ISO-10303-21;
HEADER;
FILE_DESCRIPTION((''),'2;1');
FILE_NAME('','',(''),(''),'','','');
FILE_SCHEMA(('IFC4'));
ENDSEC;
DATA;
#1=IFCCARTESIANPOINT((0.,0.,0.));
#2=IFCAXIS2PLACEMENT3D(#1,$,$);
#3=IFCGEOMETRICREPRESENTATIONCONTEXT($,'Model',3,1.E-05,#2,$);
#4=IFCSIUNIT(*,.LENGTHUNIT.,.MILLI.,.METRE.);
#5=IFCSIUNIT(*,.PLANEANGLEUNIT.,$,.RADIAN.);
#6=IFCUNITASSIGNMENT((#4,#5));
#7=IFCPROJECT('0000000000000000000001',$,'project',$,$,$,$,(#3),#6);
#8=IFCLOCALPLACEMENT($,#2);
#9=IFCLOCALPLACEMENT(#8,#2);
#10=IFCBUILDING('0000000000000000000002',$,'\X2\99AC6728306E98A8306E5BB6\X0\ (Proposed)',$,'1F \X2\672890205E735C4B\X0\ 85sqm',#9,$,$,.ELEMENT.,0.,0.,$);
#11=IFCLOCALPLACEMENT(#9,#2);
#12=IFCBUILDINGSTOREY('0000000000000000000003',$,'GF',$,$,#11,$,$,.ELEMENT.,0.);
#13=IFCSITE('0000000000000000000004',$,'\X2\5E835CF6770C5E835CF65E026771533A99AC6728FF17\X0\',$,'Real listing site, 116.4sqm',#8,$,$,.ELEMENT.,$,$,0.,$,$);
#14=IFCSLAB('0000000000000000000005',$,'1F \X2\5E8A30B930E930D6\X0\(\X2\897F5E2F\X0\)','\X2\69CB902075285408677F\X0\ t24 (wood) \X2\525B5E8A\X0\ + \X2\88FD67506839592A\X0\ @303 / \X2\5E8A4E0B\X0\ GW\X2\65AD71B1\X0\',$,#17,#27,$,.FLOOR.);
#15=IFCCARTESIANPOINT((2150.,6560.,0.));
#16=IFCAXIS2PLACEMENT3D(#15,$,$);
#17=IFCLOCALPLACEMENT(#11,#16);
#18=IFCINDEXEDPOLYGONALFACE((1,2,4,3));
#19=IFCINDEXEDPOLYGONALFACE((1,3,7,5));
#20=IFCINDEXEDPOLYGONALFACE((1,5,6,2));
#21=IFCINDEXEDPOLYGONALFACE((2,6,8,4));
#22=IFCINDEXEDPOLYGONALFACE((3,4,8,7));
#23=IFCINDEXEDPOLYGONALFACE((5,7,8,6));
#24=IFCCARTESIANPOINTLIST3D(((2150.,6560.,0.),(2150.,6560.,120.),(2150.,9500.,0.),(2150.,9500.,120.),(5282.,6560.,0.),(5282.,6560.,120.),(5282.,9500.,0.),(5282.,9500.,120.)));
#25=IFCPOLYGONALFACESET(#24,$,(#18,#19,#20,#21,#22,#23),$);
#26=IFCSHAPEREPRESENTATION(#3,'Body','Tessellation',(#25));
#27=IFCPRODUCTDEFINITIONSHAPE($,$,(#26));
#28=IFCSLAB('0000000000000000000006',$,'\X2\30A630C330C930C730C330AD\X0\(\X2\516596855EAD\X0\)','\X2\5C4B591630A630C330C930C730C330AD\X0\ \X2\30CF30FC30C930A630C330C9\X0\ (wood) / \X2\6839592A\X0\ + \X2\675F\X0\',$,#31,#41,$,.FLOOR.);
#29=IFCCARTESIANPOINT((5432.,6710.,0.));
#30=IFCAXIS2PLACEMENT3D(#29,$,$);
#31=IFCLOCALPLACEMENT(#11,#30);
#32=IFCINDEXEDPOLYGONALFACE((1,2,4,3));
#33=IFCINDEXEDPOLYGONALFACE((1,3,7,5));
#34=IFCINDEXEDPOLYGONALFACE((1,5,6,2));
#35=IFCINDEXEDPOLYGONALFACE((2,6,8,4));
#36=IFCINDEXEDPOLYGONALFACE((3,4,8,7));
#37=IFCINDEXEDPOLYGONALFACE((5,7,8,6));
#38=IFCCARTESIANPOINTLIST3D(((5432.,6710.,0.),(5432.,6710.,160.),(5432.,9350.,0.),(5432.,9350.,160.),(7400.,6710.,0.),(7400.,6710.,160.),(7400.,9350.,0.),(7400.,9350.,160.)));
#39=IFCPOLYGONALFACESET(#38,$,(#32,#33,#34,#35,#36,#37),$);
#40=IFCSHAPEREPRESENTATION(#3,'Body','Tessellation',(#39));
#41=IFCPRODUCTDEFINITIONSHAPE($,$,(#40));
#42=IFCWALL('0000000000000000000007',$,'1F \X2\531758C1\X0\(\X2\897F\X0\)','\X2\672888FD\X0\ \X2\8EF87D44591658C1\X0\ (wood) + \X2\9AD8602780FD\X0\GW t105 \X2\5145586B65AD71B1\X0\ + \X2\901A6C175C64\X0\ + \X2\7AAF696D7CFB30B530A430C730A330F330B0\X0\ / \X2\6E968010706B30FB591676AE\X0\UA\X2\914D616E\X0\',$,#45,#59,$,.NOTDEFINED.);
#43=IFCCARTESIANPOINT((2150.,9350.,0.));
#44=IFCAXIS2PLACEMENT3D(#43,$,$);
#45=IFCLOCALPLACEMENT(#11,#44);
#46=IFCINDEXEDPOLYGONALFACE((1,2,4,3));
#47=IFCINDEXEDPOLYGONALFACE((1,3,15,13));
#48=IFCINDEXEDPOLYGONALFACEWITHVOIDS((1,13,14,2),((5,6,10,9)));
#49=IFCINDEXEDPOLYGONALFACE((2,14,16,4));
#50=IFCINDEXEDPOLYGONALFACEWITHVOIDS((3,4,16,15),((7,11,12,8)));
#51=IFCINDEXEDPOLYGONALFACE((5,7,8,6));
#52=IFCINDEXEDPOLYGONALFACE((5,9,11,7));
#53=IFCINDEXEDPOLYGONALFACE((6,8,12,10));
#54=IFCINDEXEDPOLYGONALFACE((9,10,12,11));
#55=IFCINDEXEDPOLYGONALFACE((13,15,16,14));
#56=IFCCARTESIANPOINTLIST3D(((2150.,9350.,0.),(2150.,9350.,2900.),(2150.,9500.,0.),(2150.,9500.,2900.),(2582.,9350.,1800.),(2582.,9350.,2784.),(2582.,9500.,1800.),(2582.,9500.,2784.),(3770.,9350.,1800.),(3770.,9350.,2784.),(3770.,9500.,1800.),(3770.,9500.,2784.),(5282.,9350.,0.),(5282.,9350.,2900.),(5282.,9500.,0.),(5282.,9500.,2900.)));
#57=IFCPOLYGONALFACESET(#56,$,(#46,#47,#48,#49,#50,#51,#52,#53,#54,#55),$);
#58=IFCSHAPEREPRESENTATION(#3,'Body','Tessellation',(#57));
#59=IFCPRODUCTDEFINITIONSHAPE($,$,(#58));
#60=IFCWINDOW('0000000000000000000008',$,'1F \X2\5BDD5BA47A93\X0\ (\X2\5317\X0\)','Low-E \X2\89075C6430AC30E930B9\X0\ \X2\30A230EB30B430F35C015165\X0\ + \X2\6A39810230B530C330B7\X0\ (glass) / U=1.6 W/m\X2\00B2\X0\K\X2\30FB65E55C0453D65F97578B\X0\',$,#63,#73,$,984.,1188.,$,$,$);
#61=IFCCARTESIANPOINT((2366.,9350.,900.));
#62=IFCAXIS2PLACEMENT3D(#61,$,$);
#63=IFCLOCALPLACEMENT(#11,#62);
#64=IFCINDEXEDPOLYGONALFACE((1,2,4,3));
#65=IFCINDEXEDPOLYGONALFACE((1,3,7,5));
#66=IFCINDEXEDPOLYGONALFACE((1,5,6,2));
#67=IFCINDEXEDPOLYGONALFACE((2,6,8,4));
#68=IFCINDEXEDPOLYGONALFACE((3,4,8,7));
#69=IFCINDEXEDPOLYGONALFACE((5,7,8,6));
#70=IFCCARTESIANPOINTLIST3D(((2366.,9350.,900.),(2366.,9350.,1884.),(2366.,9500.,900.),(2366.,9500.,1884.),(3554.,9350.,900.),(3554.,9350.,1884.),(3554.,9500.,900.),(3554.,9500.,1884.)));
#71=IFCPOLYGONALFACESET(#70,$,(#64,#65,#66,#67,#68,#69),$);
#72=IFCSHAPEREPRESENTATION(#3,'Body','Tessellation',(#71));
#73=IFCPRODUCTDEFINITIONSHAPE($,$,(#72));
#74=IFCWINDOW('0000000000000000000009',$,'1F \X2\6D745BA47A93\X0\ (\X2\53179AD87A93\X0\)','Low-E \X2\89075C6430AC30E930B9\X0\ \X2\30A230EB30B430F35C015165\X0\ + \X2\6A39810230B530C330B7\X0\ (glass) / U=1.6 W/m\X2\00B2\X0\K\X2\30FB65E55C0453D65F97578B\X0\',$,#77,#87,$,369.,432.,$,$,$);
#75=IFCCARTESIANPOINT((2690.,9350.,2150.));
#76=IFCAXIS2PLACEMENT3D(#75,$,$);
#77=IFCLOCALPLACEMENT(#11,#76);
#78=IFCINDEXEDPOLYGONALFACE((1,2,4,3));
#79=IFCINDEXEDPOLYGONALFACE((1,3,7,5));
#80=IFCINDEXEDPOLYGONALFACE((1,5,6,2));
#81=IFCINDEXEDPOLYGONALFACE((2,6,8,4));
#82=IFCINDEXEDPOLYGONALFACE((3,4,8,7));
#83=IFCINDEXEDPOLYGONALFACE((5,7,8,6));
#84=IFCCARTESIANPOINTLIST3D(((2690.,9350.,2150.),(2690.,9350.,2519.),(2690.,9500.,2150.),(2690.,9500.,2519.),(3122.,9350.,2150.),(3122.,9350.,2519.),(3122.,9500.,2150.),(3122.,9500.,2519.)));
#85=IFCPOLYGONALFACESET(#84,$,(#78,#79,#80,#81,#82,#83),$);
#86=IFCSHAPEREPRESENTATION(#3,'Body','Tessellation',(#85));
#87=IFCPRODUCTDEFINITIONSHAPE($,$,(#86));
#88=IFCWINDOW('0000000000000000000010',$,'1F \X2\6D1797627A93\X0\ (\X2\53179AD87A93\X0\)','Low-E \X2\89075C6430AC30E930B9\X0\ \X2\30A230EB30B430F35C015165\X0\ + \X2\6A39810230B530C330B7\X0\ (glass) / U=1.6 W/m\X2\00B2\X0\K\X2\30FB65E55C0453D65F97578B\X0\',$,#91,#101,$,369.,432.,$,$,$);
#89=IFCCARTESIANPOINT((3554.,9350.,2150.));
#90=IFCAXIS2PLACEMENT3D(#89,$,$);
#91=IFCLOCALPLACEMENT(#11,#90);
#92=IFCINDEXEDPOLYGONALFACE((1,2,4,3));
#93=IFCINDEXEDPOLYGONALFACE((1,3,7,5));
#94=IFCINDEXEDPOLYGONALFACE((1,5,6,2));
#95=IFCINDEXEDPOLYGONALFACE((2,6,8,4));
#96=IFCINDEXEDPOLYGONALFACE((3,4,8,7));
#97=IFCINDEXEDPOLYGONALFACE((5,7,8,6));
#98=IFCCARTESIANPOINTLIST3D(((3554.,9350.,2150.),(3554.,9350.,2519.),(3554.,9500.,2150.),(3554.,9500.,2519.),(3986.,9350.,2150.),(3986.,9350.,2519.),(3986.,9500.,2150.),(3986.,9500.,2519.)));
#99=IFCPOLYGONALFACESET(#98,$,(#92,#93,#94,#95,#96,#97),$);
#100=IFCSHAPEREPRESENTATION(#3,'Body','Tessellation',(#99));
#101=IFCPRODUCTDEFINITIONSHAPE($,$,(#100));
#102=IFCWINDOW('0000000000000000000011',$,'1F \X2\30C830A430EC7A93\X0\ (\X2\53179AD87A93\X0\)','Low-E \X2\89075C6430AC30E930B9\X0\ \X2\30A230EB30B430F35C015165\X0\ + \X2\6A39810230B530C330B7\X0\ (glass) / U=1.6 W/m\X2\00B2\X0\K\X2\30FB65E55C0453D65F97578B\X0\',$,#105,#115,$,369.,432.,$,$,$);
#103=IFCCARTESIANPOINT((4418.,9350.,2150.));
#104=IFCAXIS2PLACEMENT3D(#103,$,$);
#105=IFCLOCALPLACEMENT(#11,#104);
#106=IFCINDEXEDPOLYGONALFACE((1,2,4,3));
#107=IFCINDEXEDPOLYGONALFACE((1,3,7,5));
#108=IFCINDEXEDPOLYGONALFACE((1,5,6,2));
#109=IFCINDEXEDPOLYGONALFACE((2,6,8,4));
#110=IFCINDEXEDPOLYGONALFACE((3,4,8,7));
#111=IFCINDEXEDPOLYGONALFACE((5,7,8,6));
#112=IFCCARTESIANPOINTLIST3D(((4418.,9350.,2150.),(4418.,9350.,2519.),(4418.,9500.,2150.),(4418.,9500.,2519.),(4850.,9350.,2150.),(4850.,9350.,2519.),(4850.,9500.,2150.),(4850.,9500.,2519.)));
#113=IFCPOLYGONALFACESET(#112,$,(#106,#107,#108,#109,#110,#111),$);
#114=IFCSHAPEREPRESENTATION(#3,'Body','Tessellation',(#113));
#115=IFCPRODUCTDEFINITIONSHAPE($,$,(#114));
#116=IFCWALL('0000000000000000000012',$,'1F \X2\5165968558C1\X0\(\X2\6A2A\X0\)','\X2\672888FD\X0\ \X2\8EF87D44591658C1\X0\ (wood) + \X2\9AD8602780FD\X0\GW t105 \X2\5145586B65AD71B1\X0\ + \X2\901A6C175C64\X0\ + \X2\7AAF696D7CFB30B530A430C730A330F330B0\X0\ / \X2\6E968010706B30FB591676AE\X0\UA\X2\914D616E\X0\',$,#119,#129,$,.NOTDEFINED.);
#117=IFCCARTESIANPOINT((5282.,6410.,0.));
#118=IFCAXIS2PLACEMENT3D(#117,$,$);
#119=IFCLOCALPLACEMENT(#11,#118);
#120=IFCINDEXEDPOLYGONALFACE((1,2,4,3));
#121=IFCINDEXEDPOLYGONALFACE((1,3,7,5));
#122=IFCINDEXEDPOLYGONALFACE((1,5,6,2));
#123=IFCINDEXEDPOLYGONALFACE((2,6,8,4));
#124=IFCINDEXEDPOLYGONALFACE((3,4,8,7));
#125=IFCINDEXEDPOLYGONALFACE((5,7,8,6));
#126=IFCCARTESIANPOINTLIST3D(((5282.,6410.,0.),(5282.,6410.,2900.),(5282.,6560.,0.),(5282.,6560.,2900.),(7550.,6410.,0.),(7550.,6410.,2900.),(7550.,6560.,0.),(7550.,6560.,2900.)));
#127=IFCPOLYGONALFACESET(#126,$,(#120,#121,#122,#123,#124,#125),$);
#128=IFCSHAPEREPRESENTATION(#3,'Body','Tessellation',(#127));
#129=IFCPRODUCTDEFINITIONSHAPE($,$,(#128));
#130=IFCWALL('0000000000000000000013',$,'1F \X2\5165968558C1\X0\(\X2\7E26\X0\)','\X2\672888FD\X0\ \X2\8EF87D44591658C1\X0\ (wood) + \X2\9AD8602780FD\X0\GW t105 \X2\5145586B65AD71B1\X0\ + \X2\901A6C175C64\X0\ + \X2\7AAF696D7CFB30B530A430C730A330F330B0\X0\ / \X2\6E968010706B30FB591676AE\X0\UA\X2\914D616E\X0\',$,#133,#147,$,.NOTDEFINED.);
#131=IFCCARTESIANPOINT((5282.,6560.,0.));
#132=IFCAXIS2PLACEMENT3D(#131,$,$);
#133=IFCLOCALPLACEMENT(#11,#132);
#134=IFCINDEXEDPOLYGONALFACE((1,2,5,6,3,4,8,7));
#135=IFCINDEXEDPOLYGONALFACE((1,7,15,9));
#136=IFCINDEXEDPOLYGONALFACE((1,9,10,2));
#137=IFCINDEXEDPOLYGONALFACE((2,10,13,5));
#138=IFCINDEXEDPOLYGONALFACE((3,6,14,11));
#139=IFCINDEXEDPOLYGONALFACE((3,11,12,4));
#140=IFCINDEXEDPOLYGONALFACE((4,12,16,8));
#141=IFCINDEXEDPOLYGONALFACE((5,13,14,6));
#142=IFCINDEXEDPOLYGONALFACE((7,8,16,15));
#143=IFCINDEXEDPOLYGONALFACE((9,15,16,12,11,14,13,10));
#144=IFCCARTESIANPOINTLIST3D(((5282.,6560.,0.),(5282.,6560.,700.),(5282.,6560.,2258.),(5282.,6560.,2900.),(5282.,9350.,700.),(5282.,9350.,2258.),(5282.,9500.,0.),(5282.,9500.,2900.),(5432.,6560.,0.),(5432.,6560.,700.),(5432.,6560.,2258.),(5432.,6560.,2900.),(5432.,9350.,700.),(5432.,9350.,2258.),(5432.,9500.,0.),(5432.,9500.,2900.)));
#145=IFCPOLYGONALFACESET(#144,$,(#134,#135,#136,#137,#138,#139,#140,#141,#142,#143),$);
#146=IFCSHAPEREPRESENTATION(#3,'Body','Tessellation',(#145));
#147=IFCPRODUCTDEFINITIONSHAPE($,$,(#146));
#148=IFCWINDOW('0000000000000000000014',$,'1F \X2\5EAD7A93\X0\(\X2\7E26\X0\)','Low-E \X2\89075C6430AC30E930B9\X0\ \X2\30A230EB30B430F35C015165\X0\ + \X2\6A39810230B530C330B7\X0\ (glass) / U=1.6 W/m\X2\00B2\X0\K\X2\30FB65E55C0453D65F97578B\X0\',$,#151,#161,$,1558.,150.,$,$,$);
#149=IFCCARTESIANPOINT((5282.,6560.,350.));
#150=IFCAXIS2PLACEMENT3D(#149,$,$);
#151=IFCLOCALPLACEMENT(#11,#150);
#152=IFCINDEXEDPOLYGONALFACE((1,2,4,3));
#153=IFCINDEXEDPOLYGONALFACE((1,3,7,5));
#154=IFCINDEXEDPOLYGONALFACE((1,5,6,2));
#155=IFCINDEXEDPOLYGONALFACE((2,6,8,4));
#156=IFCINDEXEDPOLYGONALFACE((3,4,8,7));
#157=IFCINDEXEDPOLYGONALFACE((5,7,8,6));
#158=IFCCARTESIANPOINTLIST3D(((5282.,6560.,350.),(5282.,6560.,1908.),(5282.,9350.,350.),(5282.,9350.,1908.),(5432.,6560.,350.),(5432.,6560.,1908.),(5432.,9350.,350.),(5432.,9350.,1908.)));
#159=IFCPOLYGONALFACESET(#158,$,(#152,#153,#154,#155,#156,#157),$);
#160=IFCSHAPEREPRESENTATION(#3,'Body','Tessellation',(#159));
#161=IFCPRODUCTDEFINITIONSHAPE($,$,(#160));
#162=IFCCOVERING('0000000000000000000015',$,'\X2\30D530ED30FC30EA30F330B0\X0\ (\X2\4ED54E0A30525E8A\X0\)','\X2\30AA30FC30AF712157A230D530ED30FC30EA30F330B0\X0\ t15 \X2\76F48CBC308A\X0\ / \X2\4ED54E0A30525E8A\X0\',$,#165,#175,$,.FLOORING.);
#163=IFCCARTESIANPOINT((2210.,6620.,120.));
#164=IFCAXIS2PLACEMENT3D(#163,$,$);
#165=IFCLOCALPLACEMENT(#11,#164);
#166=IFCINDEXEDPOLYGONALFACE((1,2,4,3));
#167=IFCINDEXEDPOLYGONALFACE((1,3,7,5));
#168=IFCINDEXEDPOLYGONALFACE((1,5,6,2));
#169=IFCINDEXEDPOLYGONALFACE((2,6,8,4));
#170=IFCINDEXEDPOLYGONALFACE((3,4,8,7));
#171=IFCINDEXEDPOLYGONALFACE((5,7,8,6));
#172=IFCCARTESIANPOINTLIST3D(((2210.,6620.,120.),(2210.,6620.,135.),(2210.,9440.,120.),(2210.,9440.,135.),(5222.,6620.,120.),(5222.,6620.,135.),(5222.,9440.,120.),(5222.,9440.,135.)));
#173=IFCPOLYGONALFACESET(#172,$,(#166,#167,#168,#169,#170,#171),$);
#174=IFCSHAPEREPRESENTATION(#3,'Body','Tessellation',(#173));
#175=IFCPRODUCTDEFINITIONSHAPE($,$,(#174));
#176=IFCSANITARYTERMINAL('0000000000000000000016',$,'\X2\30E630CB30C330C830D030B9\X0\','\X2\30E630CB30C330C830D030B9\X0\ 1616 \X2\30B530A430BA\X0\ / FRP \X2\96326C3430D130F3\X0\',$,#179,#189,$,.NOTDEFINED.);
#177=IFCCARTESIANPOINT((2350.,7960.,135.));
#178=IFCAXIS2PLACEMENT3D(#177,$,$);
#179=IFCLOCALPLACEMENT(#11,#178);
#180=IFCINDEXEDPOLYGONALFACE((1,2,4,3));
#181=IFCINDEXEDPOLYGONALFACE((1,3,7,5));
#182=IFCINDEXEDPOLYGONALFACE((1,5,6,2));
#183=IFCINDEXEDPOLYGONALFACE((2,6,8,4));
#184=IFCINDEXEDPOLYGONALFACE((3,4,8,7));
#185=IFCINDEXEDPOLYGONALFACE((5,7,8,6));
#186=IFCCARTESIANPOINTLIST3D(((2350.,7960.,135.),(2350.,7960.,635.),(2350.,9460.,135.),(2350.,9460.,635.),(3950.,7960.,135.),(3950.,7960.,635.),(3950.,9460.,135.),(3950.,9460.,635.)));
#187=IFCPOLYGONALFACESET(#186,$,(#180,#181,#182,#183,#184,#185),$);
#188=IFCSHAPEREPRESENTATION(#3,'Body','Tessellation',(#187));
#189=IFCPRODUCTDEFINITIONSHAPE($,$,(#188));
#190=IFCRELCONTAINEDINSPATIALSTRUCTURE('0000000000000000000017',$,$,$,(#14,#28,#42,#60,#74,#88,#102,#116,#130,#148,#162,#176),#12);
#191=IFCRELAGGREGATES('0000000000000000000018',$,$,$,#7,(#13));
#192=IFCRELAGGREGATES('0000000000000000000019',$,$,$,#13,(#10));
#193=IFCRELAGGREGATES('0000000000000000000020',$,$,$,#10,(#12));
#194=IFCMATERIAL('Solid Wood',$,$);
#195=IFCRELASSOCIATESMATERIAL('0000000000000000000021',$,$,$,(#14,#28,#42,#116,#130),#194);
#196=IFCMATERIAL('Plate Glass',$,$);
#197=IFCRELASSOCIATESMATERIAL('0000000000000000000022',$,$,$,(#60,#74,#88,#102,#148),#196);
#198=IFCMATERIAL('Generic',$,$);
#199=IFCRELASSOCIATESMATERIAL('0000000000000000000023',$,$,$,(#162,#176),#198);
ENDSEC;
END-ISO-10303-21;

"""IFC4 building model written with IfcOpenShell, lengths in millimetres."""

from ifc_helpers import new_model, si_unit, frame, frame_2d, origin, place, context, project, spatial, rectangle, extrude, material, element, fill, save


model = new_model("IFC4")

# Units and contexts
model_context = context("Model", 3, precision=1e-05, world=origin())
ifc_project = project(units=[si_unit("LENGTHUNIT", "METRE", prefix="MILLI"), si_unit("PLANEANGLEUNIT", "RADIAN")], contexts=[model_context])

# Site, building, storey
site_placement = place(None, origin())
site = spatial("IfcSite", under=ifc_project, at=site_placement, Name="広島県広島市東区馬木７", ObjectType="Real listing site, 116.4sqm", CompositionType="ELEMENT", RefElevation=0.0)
building_placement = place(site_placement, origin())
building = spatial("IfcBuilding", under=site, at=building_placement, Name="馬木の風の家 (Proposed)", ObjectType="1F 木造平屋 85sqm", CompositionType="ELEMENT", ElevationOfRefHeight=0.0, ElevationOfTerrain=0.0)
storey_placement = place(building_placement, origin())
storey = spatial("IfcBuildingStorey", under=building, at=storey_placement, Name="GF", CompositionType="ELEMENT", Elevation=0.0)

# Slabs
ifc_material_1 = material(Name="Solid Wood")
slab_1_placement = place(storey_placement, frame((2150.0, 6560.0, 0.0)))
element("IfcSlab", 1, at=slab_1_placement, inside=storey, material=ifc_material_1, Name="1F 床スラブ(西帯)", Description="構造用合板 t24 (wood) 剛床 + 製材根太 @303 / 床下 GW断熱", PredefinedType="FLOOR", context=model_context, shape_type="SweptSolid", body=[
    extrude(rectangle(XDim=3132.0, YDim=2940.0, at=frame_2d((1566.0, 1470.0))), frame((2150.0, 6560.0, 0.0)), (0.0, 0.0, 1.0), 120.0),
])
slab_2_placement = place(storey_placement, frame((5432.0, 6710.0, 0.0)))
element("IfcSlab", 2, at=slab_2_placement, inside=storey, material=ifc_material_1, Name="ウッドデッキ(入隅庭)", Description="屋外ウッドデッキ ハードウッド (wood) / 根太 + 束", PredefinedType="FLOOR", context=model_context, shape_type="SweptSolid", body=[
    extrude(rectangle(XDim=1968.0, YDim=2640.0, at=frame_2d((984.0, 1320.0))), frame((5432.0, 6710.0, 0.0)), (0.0, 0.0, 1.0), 160.0),
])

# Wall, openings, windows
wall_1_placement = place(storey_placement, frame((2150.0, 9350.0, 0.0)))
wall_1 = element("IfcWall", 3, at=wall_1_placement, inside=storey, material=ifc_material_1, Name="1F 北壁(西)", Description="木製 軸組外壁 (wood) + 高性能GW t105 充填断熱 + 通気層 + 窯業系サイディング / 準耐火・外皮UA配慮", PredefinedType="NOTDEFINED", context=model_context, shape_type="SweptSolid", body=[
    extrude(rectangle(XDim=3132.0, YDim=150.0, at=frame_2d((1566.0, 75.0))), frame((2150.0, 9350.0, 0.0)), (0.0, 0.0, 1.0), 2900.0),
])
opening_1_placement = place(storey_placement, frame((2366.0, 9350.0, 900.0)))
opening_1 = element("IfcOpeningElement", 4, at=opening_1_placement, cuts=wall_1, PredefinedType="NOTDEFINED", context=model_context, shape_type="SweptSolid", body=[
    extrude(rectangle(XDim=1188.0, YDim=150.0, at=frame_2d((594.0, 75.0))), frame((2366.0, 9350.0, 900.0)), (0.0, 0.0, 1.0), 984.0),
])
opening_2_placement = place(storey_placement, frame((2690.0, 9350.0, 2150.0)))
opening_2 = element("IfcOpeningElement", 5, at=opening_2_placement, cuts=wall_1, PredefinedType="NOTDEFINED", context=model_context, shape_type="SweptSolid", body=[
    extrude(rectangle(XDim=432.0, YDim=150.0, at=frame_2d((216.0, 75.0))), frame((2690.0, 9350.0, 2150.0)), (0.0, 0.0, 1.0), 369.0),
])
opening_3_placement = place(storey_placement, frame((3554.0, 9350.0, 2150.0)))
opening_3 = element("IfcOpeningElement", 6, at=opening_3_placement, cuts=wall_1, PredefinedType="NOTDEFINED", context=model_context, shape_type="SweptSolid", body=[
    extrude(rectangle(XDim=432.0, YDim=150.0, at=frame_2d((216.0, 75.0))), frame((3554.0, 9350.0, 2150.0)), (0.0, 0.0, 1.0), 369.0),
])
opening_4_placement = place(storey_placement, frame((4418.0, 9350.0, 2150.0)))
opening_4 = element("IfcOpeningElement", 7, at=opening_4_placement, cuts=wall_1, PredefinedType="NOTDEFINED", context=model_context, shape_type="SweptSolid", body=[
    extrude(rectangle(XDim=432.0, YDim=150.0, at=frame_2d((216.0, 75.0))), frame((4418.0, 9350.0, 2150.0)), (0.0, 0.0, 1.0), 369.0),
])
ifc_material_2 = material(Name="Plate Glass")
window_1_placement = place(storey_placement, frame((2366.0, 9350.0, 900.0)))
window_1 = element("IfcWindow", 8, at=window_1_placement, inside=storey, material=ifc_material_2, Name="1F 寝室窓 (北)", Description="Low-E 複層ガラス アルゴン封入 + 樹脂サッシ (glass) / U=1.6 W/m²K・日射取得型", OverallHeight=984.0, OverallWidth=1188.0, context=model_context, shape_type="SweptSolid", body=[
    extrude(rectangle(XDim=1188.0, YDim=150.0, at=frame_2d((594.0, 75.0))), frame((2366.0, 9350.0, 900.0)), (0.0, 0.0, 1.0), 984.0),
])
fill(opening_1, window_1)
window_2_placement = place(storey_placement, frame((2690.0, 9350.0, 2150.0)))
window_2 = element("IfcWindow", 9, at=window_2_placement, inside=storey, material=ifc_material_2, Name="1F 浴室窓 (北高窓)", Description="Low-E 複層ガラス アルゴン封入 + 樹脂サッシ (glass) / U=1.6 W/m²K・日射取得型", OverallHeight=369.0, OverallWidth=432.0, context=model_context, shape_type="SweptSolid", body=[
    extrude(rectangle(XDim=432.0, YDim=150.0, at=frame_2d((216.0, 75.0))), frame((2690.0, 9350.0, 2150.0)), (0.0, 0.0, 1.0), 369.0),
])
fill(opening_2, window_2)
window_3_placement = place(storey_placement, frame((3554.0, 9350.0, 2150.0)))
window_3 = element("IfcWindow", 10, at=window_3_placement, inside=storey, material=ifc_material_2, Name="1F 洗面窓 (北高窓)", Description="Low-E 複層ガラス アルゴン封入 + 樹脂サッシ (glass) / U=1.6 W/m²K・日射取得型", OverallHeight=369.0, OverallWidth=432.0, context=model_context, shape_type="SweptSolid", body=[
    extrude(rectangle(XDim=432.0, YDim=150.0, at=frame_2d((216.0, 75.0))), frame((3554.0, 9350.0, 2150.0)), (0.0, 0.0, 1.0), 369.0),
])
fill(opening_3, window_3)
window_4_placement = place(storey_placement, frame((4418.0, 9350.0, 2150.0)))
window_4 = element("IfcWindow", 11, at=window_4_placement, inside=storey, material=ifc_material_2, Name="1F トイレ窓 (北高窓)", Description="Low-E 複層ガラス アルゴン封入 + 樹脂サッシ (glass) / U=1.6 W/m²K・日射取得型", OverallHeight=369.0, OverallWidth=432.0, context=model_context, shape_type="SweptSolid", body=[
    extrude(rectangle(XDim=432.0, YDim=150.0, at=frame_2d((216.0, 75.0))), frame((4418.0, 9350.0, 2150.0)), (0.0, 0.0, 1.0), 369.0),
])
fill(opening_4, window_4)

# Wall
wall_2_placement = place(storey_placement, frame((5282.0, 6410.0, 0.0)))
element("IfcWall", 12, at=wall_2_placement, inside=storey, material=ifc_material_1, Name="1F 入隅壁(横)", Description="木製 軸組外壁 (wood) + 高性能GW t105 充填断熱 + 通気層 + 窯業系サイディング / 準耐火・外皮UA配慮", PredefinedType="NOTDEFINED", context=model_context, shape_type="SweptSolid", body=[
    extrude(rectangle(XDim=2268.0, YDim=150.0, at=frame_2d((1134.0, 75.0))), frame((5282.0, 6410.0, 0.0)), (0.0, 0.0, 1.0), 2900.0),
])

# Wall, opening, window
wall_3_placement = place(storey_placement, frame((5282.0, 6560.0, 0.0)))
wall_3 = element("IfcWall", 13, at=wall_3_placement, inside=storey, material=ifc_material_1, Name="1F 入隅壁(縦)", Description="木製 軸組外壁 (wood) + 高性能GW t105 充填断熱 + 通気層 + 窯業系サイディング / 準耐火・外皮UA配慮", PredefinedType="NOTDEFINED", context=model_context, shape_type="SweptSolid", body=[
    extrude(rectangle(XDim=150.0, YDim=2940.0, at=frame_2d((75.0, 1470.0))), frame((5282.0, 6560.0, 0.0)), (0.0, 0.0, 1.0), 2900.0),
])
opening_5_placement = place(storey_placement, frame((5282.0, 6560.0, 350.0)))
opening_5 = element("IfcOpeningElement", 14, at=opening_5_placement, cuts=wall_3, PredefinedType="NOTDEFINED", context=model_context, shape_type="SweptSolid", body=[
    extrude(rectangle(XDim=150.0, YDim=2790.0, at=frame_2d((75.0, 1395.0))), frame((5282.0, 6560.0, 350.0)), (0.0, 0.0, 1.0), 1558.0),
])
window_5_placement = place(storey_placement, frame((5282.0, 6560.0, 350.0)))
window_5 = element("IfcWindow", 15, at=window_5_placement, inside=storey, material=ifc_material_2, Name="1F 庭窓(縦)", Description="Low-E 複層ガラス アルゴン封入 + 樹脂サッシ (glass) / U=1.6 W/m²K・日射取得型", OverallHeight=1558.0, OverallWidth=150.0, context=model_context, shape_type="SweptSolid", body=[
    extrude(rectangle(XDim=150.0, YDim=2790.0, at=frame_2d((75.0, 1395.0))), frame((5282.0, 6560.0, 350.0)), (0.0, 0.0, 1.0), 1558.0),
])
fill(opening_5, window_5)

# Covering
ifc_material_3 = material(Name="Generic")
covering_placement = place(storey_placement, frame((2210.0, 6620.0, 120.0)))
element("IfcCovering", 16, at=covering_placement, inside=storey, material=ifc_material_3, Name="フローリング (仕上げ床)", Description="オーク無垢フローリング t15 直貼り / 仕上げ床", PredefinedType="FLOORING", context=model_context, shape_type="SweptSolid", body=[
    extrude(rectangle(XDim=3012.0, YDim=2820.0, at=frame_2d((1506.0, 1410.0))), frame((2210.0, 6620.0, 120.0)), (0.0, 0.0, 1.0), 15.0),
])

# Sanitary terminal
sanitary_terminal_1_placement = place(storey_placement, frame((2350.0, 7960.0, 135.0)))
element("IfcSanitaryTerminal", 17, at=sanitary_terminal_1_placement, inside=storey, material=ifc_material_3, Name="ユニットバス", Description="ユニットバス 1616 サイズ / FRP 防水パン", PredefinedType="NOTDEFINED", context=model_context, shape_type="SweptSolid", body=[
    extrude(rectangle(XDim=1600.0, YDim=1500.0, at=frame_2d((800.0, 750.0))), frame((2350.0, 7960.0, 135.0)), (0.0, 0.0, 1.0), 500.0),
])

save(model, "model.ifc")
